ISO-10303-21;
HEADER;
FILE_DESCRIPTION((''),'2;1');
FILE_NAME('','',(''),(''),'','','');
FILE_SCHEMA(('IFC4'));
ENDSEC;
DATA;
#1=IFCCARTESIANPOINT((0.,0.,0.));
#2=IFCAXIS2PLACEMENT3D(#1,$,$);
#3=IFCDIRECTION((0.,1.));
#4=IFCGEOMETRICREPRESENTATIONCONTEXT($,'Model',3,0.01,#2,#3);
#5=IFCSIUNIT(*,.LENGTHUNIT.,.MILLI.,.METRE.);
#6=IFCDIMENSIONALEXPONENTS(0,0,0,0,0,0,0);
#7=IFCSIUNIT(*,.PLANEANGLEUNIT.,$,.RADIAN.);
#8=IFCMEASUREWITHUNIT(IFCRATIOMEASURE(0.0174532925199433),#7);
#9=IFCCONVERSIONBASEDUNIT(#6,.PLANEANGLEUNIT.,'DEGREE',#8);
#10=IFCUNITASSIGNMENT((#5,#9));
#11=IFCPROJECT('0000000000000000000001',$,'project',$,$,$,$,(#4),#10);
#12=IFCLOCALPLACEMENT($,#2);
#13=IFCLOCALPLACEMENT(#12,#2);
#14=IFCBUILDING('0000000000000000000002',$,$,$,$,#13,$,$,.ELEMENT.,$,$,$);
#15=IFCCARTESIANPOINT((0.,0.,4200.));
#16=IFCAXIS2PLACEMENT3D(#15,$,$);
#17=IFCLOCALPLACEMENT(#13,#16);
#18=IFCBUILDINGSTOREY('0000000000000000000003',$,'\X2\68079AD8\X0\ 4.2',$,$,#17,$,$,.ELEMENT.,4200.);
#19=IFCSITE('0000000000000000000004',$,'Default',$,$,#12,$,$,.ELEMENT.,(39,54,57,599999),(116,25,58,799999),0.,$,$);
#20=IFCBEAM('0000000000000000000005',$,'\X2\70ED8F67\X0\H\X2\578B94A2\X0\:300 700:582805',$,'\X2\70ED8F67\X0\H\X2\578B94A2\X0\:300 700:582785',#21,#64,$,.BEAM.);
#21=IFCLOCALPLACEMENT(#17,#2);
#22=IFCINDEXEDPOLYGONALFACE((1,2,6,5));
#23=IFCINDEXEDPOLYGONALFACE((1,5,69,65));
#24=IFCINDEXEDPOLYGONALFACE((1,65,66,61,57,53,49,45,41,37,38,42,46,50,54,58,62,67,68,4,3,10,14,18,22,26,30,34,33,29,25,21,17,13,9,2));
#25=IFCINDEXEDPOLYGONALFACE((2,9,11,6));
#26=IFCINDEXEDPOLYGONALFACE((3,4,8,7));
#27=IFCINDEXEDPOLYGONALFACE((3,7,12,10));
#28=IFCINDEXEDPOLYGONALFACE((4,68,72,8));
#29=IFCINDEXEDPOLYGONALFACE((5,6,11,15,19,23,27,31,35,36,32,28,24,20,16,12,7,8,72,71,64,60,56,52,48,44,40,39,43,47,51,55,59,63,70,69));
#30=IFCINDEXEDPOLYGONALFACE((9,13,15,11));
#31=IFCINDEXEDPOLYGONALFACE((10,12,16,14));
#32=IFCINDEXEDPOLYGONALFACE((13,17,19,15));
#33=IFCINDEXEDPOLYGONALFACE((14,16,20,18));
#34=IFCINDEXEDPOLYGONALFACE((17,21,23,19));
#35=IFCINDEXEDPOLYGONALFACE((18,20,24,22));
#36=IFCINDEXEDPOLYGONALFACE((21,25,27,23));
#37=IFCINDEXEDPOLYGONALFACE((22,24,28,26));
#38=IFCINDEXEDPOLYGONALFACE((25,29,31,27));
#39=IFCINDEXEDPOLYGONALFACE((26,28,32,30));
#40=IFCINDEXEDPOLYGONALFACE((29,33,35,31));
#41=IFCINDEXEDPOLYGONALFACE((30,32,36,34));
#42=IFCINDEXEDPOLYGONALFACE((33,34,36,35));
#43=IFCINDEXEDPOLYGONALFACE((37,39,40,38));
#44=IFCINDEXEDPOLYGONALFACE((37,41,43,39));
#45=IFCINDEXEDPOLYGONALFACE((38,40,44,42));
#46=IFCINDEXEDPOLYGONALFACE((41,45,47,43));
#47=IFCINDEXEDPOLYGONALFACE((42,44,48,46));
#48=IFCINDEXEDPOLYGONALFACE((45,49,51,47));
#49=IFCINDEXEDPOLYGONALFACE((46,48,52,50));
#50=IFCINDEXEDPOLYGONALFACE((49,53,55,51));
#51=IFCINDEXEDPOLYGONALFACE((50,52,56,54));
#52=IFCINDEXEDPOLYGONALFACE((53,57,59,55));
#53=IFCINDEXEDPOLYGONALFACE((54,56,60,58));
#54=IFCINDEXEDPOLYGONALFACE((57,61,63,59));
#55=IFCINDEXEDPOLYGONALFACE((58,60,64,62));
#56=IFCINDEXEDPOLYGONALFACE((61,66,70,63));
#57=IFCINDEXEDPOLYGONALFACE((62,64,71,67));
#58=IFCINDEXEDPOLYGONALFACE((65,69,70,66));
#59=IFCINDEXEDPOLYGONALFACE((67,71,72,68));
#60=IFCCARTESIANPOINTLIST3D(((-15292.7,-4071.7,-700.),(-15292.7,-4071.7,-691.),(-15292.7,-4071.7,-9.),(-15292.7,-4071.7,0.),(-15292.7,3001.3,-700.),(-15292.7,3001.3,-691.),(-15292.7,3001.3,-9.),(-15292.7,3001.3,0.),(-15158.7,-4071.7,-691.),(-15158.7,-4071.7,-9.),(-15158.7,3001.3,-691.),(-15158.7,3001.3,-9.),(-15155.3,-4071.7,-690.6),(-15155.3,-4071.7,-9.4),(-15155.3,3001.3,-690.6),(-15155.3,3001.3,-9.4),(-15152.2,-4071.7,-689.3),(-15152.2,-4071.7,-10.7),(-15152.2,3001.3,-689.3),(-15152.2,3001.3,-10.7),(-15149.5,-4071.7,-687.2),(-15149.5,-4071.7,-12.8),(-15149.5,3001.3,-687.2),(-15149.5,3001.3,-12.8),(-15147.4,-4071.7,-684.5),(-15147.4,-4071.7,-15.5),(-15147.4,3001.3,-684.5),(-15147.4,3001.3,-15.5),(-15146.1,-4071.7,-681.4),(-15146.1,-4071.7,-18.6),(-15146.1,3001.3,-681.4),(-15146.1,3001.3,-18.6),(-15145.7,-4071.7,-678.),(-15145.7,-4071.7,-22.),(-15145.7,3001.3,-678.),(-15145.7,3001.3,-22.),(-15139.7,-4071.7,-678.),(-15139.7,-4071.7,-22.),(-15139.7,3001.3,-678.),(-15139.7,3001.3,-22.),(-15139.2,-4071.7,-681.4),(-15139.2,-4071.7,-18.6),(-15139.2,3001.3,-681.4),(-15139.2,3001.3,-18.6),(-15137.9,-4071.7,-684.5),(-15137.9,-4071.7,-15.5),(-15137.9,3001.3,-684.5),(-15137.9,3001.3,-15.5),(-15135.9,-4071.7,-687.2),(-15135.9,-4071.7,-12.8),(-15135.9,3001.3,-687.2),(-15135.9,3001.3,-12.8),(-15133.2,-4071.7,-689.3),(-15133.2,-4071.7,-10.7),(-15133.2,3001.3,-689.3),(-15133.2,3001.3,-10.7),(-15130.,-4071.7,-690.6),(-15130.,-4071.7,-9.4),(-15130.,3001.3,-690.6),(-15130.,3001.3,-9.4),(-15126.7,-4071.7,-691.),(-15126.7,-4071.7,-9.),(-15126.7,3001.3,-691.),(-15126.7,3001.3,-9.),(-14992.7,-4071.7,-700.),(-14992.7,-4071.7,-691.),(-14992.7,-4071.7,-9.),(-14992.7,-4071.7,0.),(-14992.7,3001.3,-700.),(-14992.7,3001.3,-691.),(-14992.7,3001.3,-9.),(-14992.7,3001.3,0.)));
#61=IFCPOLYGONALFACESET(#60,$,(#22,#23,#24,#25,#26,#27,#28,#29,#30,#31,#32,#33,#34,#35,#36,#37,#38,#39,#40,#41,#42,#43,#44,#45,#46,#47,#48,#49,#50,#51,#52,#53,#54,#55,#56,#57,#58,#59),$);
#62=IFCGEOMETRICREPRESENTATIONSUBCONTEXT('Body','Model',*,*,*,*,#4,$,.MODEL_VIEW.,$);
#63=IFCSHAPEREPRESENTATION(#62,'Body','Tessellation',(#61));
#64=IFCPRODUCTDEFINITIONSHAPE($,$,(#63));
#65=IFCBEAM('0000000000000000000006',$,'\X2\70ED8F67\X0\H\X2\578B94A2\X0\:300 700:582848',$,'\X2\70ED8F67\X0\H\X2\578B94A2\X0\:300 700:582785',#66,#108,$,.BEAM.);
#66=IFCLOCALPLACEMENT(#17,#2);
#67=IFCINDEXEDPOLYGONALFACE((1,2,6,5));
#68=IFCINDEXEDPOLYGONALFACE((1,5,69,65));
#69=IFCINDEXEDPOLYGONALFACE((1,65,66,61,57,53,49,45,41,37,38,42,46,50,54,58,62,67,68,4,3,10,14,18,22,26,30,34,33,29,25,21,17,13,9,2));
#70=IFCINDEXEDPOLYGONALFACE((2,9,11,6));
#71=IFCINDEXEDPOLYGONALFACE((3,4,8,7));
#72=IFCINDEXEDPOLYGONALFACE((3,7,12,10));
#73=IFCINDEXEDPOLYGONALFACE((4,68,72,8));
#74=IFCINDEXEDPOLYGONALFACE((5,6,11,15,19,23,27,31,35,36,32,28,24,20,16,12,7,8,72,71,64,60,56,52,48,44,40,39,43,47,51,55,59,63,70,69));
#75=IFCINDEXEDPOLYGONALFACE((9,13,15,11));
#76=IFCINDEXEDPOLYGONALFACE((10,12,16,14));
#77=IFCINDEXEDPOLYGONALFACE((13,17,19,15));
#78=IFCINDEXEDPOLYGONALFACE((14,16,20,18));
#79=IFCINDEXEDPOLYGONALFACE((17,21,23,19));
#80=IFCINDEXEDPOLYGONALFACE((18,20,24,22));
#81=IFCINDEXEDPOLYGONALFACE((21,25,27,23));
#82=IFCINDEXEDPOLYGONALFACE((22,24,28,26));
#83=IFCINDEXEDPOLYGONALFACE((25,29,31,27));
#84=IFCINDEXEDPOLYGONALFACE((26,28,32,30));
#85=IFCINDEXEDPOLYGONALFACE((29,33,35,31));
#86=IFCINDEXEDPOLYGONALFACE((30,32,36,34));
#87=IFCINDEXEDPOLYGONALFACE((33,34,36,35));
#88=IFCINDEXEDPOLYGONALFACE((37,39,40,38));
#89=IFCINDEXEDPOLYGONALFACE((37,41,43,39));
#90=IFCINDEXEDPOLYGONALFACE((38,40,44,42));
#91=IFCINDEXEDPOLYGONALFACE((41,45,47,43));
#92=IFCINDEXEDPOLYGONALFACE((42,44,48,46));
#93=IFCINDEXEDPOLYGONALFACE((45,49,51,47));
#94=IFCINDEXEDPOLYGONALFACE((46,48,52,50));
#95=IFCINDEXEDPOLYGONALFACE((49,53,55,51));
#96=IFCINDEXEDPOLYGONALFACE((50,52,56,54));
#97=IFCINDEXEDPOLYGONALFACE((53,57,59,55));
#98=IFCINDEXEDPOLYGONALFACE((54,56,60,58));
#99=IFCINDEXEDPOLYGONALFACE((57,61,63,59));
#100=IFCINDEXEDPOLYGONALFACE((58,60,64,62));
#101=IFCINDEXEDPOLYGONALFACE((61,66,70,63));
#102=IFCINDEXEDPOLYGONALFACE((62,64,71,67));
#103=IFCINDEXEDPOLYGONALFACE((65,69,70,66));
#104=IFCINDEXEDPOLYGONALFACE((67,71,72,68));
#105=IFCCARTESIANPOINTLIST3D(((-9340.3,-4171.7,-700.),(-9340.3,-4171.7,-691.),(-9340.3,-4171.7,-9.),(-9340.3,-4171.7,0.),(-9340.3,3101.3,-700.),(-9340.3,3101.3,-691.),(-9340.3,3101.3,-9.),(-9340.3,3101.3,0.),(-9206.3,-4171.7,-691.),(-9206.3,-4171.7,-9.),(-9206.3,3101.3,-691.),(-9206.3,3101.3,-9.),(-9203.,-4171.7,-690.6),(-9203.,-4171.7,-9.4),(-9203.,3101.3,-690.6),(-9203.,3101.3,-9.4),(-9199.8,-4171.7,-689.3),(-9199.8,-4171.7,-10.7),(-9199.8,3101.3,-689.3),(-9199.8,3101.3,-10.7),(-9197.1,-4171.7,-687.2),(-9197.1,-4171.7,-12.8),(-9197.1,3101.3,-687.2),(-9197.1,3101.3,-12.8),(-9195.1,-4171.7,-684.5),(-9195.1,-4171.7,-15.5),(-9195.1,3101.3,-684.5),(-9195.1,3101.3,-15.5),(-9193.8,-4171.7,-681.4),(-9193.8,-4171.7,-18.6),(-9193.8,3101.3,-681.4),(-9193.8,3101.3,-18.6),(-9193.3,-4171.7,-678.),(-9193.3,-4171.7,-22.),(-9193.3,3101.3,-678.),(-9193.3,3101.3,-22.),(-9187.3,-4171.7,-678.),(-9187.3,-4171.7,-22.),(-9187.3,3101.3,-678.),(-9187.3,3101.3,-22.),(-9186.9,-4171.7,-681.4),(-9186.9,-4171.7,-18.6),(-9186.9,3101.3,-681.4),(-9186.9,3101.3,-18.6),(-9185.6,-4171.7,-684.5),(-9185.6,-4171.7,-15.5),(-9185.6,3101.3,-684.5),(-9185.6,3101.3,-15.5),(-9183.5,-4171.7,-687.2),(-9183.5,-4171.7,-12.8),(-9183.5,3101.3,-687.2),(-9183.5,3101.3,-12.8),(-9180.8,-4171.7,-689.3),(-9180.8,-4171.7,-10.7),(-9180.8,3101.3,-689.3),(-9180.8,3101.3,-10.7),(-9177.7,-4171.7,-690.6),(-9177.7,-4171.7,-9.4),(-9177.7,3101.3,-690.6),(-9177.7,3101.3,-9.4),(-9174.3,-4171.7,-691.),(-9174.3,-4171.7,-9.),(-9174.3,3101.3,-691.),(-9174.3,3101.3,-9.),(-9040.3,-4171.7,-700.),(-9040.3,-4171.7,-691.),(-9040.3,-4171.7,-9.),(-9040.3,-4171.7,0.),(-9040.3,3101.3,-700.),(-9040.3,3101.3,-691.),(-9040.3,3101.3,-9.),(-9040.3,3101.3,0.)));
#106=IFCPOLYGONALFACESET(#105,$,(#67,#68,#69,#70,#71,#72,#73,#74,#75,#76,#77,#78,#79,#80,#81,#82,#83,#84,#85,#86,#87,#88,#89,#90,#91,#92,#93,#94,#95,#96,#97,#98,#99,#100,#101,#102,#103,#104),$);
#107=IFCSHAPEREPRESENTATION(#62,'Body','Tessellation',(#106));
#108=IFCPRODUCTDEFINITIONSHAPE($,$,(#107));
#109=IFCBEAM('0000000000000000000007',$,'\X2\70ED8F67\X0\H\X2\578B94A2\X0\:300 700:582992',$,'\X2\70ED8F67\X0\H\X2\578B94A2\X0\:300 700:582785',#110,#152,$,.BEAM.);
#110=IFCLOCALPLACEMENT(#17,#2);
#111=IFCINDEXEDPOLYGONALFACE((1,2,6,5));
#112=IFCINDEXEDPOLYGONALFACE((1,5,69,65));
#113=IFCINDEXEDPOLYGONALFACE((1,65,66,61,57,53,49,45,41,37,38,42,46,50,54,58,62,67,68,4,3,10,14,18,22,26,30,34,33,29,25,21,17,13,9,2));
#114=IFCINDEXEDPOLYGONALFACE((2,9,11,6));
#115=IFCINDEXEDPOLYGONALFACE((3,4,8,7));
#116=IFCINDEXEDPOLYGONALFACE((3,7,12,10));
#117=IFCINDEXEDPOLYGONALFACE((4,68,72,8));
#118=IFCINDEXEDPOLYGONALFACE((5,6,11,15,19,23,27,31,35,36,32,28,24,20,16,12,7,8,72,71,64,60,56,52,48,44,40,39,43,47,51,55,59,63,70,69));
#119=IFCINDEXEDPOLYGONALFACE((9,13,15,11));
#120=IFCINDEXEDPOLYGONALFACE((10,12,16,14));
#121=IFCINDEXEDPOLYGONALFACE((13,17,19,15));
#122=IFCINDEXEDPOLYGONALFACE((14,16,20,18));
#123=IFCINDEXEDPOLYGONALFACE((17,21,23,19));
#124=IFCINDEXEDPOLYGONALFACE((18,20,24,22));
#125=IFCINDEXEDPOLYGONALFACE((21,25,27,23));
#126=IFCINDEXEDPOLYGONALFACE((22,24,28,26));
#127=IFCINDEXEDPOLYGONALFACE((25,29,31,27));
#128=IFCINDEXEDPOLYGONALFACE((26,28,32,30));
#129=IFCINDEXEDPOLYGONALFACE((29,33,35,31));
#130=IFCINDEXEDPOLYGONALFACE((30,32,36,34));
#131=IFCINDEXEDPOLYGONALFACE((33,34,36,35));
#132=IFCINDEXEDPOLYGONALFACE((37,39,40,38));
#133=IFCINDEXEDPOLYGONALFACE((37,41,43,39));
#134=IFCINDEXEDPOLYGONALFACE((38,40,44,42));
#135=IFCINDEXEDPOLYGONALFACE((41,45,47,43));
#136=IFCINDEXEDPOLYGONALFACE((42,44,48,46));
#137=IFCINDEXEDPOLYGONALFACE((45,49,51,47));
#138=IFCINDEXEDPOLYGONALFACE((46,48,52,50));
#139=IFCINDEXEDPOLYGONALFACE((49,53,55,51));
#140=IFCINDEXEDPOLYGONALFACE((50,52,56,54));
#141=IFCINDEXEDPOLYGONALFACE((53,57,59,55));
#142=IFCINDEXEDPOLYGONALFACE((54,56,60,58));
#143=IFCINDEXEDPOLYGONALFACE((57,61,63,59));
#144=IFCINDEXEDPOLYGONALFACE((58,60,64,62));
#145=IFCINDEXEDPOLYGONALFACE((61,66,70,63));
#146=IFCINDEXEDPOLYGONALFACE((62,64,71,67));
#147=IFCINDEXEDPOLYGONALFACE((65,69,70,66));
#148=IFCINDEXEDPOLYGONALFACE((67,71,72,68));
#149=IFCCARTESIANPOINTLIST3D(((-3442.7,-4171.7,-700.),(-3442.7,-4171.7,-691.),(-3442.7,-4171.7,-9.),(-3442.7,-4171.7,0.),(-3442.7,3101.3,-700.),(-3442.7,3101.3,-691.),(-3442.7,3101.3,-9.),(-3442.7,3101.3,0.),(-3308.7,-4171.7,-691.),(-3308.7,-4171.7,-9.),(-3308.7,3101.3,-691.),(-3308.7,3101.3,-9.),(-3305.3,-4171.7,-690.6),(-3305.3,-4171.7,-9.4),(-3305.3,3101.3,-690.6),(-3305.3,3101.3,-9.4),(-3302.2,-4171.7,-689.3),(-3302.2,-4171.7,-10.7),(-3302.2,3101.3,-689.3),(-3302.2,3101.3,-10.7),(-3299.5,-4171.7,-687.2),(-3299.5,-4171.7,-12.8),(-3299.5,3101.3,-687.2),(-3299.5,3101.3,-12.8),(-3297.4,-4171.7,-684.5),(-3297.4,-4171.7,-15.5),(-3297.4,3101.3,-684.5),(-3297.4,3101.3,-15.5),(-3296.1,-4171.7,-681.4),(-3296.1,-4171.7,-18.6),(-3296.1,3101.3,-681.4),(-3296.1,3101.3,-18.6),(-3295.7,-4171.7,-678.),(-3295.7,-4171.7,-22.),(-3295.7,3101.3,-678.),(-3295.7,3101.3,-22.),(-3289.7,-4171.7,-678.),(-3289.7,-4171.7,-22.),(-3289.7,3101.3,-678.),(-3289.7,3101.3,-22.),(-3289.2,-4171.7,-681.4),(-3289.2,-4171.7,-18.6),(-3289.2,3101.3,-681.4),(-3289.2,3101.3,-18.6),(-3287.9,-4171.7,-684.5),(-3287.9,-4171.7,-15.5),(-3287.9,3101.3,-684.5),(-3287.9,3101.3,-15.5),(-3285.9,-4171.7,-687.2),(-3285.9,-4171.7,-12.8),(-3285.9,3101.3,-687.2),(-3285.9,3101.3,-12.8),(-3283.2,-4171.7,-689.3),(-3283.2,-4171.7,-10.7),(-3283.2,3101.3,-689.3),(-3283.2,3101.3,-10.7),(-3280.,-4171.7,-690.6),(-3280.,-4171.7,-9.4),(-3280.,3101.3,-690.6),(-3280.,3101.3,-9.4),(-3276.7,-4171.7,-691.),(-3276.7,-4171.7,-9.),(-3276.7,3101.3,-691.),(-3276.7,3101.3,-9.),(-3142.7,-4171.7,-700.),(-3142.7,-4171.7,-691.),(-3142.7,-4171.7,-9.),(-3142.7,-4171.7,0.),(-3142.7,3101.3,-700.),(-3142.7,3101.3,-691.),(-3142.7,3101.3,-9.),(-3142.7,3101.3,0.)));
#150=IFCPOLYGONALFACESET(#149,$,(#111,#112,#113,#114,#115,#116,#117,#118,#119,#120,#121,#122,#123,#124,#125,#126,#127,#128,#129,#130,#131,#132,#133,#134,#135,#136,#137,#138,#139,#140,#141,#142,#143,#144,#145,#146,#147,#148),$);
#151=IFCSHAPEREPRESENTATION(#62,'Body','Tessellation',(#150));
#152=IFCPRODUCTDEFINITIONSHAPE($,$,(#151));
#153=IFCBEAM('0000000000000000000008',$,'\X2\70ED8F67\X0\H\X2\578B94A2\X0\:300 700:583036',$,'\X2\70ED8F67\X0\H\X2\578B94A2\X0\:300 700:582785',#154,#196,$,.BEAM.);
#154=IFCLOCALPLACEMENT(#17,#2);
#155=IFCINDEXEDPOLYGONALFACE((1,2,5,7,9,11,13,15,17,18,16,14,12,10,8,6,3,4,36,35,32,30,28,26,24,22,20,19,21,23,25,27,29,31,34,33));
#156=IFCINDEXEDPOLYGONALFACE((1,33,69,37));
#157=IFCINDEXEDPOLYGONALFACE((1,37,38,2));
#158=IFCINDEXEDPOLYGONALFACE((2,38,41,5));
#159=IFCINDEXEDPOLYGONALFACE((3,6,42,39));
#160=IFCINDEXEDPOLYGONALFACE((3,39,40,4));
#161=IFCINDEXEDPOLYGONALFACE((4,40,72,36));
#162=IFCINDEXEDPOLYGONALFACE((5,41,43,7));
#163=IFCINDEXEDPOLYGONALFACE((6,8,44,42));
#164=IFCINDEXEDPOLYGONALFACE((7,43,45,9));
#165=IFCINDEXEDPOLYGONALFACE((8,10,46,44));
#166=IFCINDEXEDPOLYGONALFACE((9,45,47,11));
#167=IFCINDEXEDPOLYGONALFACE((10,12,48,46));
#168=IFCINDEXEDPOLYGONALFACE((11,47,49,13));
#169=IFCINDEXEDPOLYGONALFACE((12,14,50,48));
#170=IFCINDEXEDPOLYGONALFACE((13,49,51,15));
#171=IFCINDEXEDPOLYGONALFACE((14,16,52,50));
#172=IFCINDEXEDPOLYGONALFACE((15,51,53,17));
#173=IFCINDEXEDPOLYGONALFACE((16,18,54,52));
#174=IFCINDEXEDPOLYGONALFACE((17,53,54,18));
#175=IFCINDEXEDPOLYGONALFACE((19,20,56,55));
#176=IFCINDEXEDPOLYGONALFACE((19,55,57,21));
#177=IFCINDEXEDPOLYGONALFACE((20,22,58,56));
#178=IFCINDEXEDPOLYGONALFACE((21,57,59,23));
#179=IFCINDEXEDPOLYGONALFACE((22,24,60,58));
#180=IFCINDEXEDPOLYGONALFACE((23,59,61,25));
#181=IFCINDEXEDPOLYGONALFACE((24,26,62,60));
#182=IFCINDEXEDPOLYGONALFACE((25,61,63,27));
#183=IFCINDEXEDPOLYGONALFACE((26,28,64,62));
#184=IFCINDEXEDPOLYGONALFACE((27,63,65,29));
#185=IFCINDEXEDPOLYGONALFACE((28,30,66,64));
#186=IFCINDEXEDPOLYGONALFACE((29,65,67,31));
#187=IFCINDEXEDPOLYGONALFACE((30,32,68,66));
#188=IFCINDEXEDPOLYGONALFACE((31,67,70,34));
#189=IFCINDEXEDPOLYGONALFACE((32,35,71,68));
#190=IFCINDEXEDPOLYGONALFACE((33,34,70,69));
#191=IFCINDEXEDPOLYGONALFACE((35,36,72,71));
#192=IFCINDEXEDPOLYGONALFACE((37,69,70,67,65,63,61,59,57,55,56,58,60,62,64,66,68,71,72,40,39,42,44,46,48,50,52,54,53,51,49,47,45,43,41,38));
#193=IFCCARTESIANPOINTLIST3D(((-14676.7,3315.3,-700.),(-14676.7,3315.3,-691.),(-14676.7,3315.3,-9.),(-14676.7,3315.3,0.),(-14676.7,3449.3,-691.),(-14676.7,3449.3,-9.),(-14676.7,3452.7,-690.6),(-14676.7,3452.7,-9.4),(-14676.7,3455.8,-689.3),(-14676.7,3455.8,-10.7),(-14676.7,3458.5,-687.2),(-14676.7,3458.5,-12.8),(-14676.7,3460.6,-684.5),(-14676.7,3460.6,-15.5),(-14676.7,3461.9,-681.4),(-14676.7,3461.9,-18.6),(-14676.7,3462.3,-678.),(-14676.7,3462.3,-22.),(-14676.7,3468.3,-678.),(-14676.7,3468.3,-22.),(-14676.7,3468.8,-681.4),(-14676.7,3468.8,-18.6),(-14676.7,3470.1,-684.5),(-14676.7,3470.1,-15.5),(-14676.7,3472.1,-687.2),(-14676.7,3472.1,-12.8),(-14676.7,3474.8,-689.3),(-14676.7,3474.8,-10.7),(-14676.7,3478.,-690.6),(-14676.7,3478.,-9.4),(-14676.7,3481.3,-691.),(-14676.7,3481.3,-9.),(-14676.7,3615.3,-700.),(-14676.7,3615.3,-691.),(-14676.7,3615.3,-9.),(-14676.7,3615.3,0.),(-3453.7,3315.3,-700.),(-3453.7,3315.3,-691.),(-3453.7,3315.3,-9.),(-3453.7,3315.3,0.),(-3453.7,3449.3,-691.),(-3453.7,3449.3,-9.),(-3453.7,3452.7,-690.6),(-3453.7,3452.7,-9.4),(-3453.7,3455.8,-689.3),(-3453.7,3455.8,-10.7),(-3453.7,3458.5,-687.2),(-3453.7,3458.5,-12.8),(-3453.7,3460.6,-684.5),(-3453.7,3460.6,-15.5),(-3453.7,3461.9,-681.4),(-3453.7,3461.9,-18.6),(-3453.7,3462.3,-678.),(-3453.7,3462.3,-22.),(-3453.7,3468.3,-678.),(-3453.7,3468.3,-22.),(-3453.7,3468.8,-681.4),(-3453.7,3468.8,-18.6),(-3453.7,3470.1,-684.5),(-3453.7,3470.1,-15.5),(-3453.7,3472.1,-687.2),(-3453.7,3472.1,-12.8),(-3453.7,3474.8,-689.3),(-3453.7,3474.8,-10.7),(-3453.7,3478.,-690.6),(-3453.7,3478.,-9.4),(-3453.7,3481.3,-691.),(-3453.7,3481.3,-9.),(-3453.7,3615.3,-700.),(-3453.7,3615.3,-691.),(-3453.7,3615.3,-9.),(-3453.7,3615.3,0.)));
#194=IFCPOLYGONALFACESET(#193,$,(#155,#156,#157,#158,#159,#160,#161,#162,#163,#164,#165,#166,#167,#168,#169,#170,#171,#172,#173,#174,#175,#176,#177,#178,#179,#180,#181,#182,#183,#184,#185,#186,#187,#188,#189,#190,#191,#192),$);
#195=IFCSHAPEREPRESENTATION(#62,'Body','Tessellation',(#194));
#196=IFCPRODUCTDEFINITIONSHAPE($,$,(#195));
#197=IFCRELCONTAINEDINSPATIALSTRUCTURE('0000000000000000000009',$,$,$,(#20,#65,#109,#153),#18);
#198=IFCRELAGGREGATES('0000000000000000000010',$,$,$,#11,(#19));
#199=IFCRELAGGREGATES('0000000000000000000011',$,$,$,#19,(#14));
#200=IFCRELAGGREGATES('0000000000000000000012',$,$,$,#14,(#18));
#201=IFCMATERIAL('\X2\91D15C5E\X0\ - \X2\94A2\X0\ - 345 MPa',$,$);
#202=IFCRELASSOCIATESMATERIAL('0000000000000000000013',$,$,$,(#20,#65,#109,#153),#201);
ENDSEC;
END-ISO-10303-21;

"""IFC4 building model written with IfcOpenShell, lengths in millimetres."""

from ifc_helpers import new_model, entity, si_unit, converted_unit, direction, frame, frame_2d, origin, place, context, subcontext, project, spatial, i_section, extrude, material, element, save


model = new_model("IFC4")

# Units and contexts
model_context = context("Model", 3, precision=0.01, world=origin(), true_north=direction((0.0, 1.0)))
body_context = subcontext(model_context, "Body", "Model", "MODEL_VIEW")
ifc_project = project(units=[si_unit("LENGTHUNIT", "METRE", prefix="MILLI"), converted_unit("PLANEANGLEUNIT", "DEGREE", entity("IfcRatioMeasure", 0.0174532925199433), si_unit("PLANEANGLEUNIT", "RADIAN"), dimensions=[0, 0, 0, 0, 0, 0, 0])], contexts=[model_context])

# Site, building, storey
site_placement = place(None, origin())
site = spatial("IfcSite", under=ifc_project, at=site_placement, Name="Default", CompositionType="ELEMENT", RefLatitude=(39, 54, 57, 599999), RefLongitude=(116, 25, 58, 799999), RefElevation=0.0)
building_placement = place(site_placement, origin())
building = spatial("IfcBuilding", under=site, at=building_placement, CompositionType="ELEMENT")
storey_placement = place(building_placement, frame((0.0, 0.0, 4200.0)))
storey = spatial("IfcBuildingStorey", under=building, at=storey_placement, Name="标高 4.2", CompositionType="ELEMENT", Elevation=4200.0)

# Beams
ifc_material_1 = material(Name="金属 - 钢 - 345 MPa")
beam_1_placement = place(storey_placement, frame((-15142.7, -4084.7, 0.0), z_axis=(0.0, 0.0, 1.0), x_axis=(0.0, 1.0, 0.0)))
element("IfcBeam", 1, at=beam_1_placement, inside=storey, material=ifc_material_1, Name="热轧H型钢:300 700:582805", ObjectType="热轧H型钢:300 700:582785", PredefinedType="BEAM", context=body_context, shape_type="SweptSolid", body=[
    extrude(i_section(OverallWidth=300.0, OverallDepth=700.0, WebThickness=6.0, FlangeThickness=9.0, FilletRadius=13.0, at=frame_2d((0.0, 0.0), x_axis=(0.0, 1.0))), frame((13.0, 0.0, -350.0), z_axis=(1.0, 0.0, 0.0), x_axis=(0.0, 0.0, -1.0)), (0.0, 0.0, 1.0), 7073.0),
])
beam_2_placement = place(storey_placement, frame((-9190.3, -4184.7, 0.0), z_axis=(0.0, 0.0, 1.0), x_axis=(0.0, 1.0, 0.0)))
element("IfcBeam", 2, at=beam_2_placement, inside=storey, material=ifc_material_1, Name="热轧H型钢:300 700:582848", ObjectType="热轧H型钢:300 700:582785", PredefinedType="BEAM", context=body_context, shape_type="SweptSolid", body=[
    extrude(i_section(OverallWidth=300.0, OverallDepth=700.0, WebThickness=6.0, FlangeThickness=9.0, FilletRadius=13.0, at=frame_2d((0.0, 0.0), x_axis=(0.0, 1.0))), frame((13.0, 0.0, -350.0), z_axis=(1.0, 0.0, 0.0), x_axis=(0.0, 0.0, -1.0)), (0.0, 0.0, 1.0), 7273.0),
])
beam_3_placement = place(storey_placement, frame((-3292.7, 3115.3, 0.0), z_axis=(0.0, 0.0, 1.0), x_axis=(0.0, -1.0, 0.0)))
element("IfcBeam", 3, at=beam_3_placement, inside=storey, material=ifc_material_1, Name="热轧H型钢:300 700:582992", ObjectType="热轧H型钢:300 700:582785", PredefinedType="BEAM", context=body_context, shape_type="SweptSolid", body=[
    extrude(i_section(OverallWidth=300.0, OverallDepth=700.0, WebThickness=6.0, FlangeThickness=9.0, FilletRadius=13.0, at=frame_2d((0.0, 0.0), x_axis=(0.0, 1.0))), frame((14.0, 0.0, -350.0), z_axis=(1.0, 0.0, 0.0), x_axis=(0.0, 0.0, -1.0)), (0.0, 0.0, 1.0), 7273.0),
])
beam_4_placement = place(storey_placement, frame((-14692.7, 3465.3, 0.0)))
element("IfcBeam", 4, at=beam_4_placement, inside=storey, material=ifc_material_1, Name="热轧H型钢:300 700:583036", ObjectType="热轧H型钢:300 700:582785", PredefinedType="BEAM", context=body_context, shape_type="SweptSolid", body=[
    extrude(i_section(OverallWidth=300.0, OverallDepth=700.0, WebThickness=6.0, FlangeThickness=9.0, FilletRadius=13.0, at=frame_2d((0.0, 0.0), x_axis=(0.0, 1.0))), frame((16.0, 0.0, -350.0), z_axis=(1.0, 0.0, 0.0), x_axis=(0.0, 0.0, -1.0)), (0.0, 0.0, 1.0), 11223.0),
])

save(model, "model.ifc")
